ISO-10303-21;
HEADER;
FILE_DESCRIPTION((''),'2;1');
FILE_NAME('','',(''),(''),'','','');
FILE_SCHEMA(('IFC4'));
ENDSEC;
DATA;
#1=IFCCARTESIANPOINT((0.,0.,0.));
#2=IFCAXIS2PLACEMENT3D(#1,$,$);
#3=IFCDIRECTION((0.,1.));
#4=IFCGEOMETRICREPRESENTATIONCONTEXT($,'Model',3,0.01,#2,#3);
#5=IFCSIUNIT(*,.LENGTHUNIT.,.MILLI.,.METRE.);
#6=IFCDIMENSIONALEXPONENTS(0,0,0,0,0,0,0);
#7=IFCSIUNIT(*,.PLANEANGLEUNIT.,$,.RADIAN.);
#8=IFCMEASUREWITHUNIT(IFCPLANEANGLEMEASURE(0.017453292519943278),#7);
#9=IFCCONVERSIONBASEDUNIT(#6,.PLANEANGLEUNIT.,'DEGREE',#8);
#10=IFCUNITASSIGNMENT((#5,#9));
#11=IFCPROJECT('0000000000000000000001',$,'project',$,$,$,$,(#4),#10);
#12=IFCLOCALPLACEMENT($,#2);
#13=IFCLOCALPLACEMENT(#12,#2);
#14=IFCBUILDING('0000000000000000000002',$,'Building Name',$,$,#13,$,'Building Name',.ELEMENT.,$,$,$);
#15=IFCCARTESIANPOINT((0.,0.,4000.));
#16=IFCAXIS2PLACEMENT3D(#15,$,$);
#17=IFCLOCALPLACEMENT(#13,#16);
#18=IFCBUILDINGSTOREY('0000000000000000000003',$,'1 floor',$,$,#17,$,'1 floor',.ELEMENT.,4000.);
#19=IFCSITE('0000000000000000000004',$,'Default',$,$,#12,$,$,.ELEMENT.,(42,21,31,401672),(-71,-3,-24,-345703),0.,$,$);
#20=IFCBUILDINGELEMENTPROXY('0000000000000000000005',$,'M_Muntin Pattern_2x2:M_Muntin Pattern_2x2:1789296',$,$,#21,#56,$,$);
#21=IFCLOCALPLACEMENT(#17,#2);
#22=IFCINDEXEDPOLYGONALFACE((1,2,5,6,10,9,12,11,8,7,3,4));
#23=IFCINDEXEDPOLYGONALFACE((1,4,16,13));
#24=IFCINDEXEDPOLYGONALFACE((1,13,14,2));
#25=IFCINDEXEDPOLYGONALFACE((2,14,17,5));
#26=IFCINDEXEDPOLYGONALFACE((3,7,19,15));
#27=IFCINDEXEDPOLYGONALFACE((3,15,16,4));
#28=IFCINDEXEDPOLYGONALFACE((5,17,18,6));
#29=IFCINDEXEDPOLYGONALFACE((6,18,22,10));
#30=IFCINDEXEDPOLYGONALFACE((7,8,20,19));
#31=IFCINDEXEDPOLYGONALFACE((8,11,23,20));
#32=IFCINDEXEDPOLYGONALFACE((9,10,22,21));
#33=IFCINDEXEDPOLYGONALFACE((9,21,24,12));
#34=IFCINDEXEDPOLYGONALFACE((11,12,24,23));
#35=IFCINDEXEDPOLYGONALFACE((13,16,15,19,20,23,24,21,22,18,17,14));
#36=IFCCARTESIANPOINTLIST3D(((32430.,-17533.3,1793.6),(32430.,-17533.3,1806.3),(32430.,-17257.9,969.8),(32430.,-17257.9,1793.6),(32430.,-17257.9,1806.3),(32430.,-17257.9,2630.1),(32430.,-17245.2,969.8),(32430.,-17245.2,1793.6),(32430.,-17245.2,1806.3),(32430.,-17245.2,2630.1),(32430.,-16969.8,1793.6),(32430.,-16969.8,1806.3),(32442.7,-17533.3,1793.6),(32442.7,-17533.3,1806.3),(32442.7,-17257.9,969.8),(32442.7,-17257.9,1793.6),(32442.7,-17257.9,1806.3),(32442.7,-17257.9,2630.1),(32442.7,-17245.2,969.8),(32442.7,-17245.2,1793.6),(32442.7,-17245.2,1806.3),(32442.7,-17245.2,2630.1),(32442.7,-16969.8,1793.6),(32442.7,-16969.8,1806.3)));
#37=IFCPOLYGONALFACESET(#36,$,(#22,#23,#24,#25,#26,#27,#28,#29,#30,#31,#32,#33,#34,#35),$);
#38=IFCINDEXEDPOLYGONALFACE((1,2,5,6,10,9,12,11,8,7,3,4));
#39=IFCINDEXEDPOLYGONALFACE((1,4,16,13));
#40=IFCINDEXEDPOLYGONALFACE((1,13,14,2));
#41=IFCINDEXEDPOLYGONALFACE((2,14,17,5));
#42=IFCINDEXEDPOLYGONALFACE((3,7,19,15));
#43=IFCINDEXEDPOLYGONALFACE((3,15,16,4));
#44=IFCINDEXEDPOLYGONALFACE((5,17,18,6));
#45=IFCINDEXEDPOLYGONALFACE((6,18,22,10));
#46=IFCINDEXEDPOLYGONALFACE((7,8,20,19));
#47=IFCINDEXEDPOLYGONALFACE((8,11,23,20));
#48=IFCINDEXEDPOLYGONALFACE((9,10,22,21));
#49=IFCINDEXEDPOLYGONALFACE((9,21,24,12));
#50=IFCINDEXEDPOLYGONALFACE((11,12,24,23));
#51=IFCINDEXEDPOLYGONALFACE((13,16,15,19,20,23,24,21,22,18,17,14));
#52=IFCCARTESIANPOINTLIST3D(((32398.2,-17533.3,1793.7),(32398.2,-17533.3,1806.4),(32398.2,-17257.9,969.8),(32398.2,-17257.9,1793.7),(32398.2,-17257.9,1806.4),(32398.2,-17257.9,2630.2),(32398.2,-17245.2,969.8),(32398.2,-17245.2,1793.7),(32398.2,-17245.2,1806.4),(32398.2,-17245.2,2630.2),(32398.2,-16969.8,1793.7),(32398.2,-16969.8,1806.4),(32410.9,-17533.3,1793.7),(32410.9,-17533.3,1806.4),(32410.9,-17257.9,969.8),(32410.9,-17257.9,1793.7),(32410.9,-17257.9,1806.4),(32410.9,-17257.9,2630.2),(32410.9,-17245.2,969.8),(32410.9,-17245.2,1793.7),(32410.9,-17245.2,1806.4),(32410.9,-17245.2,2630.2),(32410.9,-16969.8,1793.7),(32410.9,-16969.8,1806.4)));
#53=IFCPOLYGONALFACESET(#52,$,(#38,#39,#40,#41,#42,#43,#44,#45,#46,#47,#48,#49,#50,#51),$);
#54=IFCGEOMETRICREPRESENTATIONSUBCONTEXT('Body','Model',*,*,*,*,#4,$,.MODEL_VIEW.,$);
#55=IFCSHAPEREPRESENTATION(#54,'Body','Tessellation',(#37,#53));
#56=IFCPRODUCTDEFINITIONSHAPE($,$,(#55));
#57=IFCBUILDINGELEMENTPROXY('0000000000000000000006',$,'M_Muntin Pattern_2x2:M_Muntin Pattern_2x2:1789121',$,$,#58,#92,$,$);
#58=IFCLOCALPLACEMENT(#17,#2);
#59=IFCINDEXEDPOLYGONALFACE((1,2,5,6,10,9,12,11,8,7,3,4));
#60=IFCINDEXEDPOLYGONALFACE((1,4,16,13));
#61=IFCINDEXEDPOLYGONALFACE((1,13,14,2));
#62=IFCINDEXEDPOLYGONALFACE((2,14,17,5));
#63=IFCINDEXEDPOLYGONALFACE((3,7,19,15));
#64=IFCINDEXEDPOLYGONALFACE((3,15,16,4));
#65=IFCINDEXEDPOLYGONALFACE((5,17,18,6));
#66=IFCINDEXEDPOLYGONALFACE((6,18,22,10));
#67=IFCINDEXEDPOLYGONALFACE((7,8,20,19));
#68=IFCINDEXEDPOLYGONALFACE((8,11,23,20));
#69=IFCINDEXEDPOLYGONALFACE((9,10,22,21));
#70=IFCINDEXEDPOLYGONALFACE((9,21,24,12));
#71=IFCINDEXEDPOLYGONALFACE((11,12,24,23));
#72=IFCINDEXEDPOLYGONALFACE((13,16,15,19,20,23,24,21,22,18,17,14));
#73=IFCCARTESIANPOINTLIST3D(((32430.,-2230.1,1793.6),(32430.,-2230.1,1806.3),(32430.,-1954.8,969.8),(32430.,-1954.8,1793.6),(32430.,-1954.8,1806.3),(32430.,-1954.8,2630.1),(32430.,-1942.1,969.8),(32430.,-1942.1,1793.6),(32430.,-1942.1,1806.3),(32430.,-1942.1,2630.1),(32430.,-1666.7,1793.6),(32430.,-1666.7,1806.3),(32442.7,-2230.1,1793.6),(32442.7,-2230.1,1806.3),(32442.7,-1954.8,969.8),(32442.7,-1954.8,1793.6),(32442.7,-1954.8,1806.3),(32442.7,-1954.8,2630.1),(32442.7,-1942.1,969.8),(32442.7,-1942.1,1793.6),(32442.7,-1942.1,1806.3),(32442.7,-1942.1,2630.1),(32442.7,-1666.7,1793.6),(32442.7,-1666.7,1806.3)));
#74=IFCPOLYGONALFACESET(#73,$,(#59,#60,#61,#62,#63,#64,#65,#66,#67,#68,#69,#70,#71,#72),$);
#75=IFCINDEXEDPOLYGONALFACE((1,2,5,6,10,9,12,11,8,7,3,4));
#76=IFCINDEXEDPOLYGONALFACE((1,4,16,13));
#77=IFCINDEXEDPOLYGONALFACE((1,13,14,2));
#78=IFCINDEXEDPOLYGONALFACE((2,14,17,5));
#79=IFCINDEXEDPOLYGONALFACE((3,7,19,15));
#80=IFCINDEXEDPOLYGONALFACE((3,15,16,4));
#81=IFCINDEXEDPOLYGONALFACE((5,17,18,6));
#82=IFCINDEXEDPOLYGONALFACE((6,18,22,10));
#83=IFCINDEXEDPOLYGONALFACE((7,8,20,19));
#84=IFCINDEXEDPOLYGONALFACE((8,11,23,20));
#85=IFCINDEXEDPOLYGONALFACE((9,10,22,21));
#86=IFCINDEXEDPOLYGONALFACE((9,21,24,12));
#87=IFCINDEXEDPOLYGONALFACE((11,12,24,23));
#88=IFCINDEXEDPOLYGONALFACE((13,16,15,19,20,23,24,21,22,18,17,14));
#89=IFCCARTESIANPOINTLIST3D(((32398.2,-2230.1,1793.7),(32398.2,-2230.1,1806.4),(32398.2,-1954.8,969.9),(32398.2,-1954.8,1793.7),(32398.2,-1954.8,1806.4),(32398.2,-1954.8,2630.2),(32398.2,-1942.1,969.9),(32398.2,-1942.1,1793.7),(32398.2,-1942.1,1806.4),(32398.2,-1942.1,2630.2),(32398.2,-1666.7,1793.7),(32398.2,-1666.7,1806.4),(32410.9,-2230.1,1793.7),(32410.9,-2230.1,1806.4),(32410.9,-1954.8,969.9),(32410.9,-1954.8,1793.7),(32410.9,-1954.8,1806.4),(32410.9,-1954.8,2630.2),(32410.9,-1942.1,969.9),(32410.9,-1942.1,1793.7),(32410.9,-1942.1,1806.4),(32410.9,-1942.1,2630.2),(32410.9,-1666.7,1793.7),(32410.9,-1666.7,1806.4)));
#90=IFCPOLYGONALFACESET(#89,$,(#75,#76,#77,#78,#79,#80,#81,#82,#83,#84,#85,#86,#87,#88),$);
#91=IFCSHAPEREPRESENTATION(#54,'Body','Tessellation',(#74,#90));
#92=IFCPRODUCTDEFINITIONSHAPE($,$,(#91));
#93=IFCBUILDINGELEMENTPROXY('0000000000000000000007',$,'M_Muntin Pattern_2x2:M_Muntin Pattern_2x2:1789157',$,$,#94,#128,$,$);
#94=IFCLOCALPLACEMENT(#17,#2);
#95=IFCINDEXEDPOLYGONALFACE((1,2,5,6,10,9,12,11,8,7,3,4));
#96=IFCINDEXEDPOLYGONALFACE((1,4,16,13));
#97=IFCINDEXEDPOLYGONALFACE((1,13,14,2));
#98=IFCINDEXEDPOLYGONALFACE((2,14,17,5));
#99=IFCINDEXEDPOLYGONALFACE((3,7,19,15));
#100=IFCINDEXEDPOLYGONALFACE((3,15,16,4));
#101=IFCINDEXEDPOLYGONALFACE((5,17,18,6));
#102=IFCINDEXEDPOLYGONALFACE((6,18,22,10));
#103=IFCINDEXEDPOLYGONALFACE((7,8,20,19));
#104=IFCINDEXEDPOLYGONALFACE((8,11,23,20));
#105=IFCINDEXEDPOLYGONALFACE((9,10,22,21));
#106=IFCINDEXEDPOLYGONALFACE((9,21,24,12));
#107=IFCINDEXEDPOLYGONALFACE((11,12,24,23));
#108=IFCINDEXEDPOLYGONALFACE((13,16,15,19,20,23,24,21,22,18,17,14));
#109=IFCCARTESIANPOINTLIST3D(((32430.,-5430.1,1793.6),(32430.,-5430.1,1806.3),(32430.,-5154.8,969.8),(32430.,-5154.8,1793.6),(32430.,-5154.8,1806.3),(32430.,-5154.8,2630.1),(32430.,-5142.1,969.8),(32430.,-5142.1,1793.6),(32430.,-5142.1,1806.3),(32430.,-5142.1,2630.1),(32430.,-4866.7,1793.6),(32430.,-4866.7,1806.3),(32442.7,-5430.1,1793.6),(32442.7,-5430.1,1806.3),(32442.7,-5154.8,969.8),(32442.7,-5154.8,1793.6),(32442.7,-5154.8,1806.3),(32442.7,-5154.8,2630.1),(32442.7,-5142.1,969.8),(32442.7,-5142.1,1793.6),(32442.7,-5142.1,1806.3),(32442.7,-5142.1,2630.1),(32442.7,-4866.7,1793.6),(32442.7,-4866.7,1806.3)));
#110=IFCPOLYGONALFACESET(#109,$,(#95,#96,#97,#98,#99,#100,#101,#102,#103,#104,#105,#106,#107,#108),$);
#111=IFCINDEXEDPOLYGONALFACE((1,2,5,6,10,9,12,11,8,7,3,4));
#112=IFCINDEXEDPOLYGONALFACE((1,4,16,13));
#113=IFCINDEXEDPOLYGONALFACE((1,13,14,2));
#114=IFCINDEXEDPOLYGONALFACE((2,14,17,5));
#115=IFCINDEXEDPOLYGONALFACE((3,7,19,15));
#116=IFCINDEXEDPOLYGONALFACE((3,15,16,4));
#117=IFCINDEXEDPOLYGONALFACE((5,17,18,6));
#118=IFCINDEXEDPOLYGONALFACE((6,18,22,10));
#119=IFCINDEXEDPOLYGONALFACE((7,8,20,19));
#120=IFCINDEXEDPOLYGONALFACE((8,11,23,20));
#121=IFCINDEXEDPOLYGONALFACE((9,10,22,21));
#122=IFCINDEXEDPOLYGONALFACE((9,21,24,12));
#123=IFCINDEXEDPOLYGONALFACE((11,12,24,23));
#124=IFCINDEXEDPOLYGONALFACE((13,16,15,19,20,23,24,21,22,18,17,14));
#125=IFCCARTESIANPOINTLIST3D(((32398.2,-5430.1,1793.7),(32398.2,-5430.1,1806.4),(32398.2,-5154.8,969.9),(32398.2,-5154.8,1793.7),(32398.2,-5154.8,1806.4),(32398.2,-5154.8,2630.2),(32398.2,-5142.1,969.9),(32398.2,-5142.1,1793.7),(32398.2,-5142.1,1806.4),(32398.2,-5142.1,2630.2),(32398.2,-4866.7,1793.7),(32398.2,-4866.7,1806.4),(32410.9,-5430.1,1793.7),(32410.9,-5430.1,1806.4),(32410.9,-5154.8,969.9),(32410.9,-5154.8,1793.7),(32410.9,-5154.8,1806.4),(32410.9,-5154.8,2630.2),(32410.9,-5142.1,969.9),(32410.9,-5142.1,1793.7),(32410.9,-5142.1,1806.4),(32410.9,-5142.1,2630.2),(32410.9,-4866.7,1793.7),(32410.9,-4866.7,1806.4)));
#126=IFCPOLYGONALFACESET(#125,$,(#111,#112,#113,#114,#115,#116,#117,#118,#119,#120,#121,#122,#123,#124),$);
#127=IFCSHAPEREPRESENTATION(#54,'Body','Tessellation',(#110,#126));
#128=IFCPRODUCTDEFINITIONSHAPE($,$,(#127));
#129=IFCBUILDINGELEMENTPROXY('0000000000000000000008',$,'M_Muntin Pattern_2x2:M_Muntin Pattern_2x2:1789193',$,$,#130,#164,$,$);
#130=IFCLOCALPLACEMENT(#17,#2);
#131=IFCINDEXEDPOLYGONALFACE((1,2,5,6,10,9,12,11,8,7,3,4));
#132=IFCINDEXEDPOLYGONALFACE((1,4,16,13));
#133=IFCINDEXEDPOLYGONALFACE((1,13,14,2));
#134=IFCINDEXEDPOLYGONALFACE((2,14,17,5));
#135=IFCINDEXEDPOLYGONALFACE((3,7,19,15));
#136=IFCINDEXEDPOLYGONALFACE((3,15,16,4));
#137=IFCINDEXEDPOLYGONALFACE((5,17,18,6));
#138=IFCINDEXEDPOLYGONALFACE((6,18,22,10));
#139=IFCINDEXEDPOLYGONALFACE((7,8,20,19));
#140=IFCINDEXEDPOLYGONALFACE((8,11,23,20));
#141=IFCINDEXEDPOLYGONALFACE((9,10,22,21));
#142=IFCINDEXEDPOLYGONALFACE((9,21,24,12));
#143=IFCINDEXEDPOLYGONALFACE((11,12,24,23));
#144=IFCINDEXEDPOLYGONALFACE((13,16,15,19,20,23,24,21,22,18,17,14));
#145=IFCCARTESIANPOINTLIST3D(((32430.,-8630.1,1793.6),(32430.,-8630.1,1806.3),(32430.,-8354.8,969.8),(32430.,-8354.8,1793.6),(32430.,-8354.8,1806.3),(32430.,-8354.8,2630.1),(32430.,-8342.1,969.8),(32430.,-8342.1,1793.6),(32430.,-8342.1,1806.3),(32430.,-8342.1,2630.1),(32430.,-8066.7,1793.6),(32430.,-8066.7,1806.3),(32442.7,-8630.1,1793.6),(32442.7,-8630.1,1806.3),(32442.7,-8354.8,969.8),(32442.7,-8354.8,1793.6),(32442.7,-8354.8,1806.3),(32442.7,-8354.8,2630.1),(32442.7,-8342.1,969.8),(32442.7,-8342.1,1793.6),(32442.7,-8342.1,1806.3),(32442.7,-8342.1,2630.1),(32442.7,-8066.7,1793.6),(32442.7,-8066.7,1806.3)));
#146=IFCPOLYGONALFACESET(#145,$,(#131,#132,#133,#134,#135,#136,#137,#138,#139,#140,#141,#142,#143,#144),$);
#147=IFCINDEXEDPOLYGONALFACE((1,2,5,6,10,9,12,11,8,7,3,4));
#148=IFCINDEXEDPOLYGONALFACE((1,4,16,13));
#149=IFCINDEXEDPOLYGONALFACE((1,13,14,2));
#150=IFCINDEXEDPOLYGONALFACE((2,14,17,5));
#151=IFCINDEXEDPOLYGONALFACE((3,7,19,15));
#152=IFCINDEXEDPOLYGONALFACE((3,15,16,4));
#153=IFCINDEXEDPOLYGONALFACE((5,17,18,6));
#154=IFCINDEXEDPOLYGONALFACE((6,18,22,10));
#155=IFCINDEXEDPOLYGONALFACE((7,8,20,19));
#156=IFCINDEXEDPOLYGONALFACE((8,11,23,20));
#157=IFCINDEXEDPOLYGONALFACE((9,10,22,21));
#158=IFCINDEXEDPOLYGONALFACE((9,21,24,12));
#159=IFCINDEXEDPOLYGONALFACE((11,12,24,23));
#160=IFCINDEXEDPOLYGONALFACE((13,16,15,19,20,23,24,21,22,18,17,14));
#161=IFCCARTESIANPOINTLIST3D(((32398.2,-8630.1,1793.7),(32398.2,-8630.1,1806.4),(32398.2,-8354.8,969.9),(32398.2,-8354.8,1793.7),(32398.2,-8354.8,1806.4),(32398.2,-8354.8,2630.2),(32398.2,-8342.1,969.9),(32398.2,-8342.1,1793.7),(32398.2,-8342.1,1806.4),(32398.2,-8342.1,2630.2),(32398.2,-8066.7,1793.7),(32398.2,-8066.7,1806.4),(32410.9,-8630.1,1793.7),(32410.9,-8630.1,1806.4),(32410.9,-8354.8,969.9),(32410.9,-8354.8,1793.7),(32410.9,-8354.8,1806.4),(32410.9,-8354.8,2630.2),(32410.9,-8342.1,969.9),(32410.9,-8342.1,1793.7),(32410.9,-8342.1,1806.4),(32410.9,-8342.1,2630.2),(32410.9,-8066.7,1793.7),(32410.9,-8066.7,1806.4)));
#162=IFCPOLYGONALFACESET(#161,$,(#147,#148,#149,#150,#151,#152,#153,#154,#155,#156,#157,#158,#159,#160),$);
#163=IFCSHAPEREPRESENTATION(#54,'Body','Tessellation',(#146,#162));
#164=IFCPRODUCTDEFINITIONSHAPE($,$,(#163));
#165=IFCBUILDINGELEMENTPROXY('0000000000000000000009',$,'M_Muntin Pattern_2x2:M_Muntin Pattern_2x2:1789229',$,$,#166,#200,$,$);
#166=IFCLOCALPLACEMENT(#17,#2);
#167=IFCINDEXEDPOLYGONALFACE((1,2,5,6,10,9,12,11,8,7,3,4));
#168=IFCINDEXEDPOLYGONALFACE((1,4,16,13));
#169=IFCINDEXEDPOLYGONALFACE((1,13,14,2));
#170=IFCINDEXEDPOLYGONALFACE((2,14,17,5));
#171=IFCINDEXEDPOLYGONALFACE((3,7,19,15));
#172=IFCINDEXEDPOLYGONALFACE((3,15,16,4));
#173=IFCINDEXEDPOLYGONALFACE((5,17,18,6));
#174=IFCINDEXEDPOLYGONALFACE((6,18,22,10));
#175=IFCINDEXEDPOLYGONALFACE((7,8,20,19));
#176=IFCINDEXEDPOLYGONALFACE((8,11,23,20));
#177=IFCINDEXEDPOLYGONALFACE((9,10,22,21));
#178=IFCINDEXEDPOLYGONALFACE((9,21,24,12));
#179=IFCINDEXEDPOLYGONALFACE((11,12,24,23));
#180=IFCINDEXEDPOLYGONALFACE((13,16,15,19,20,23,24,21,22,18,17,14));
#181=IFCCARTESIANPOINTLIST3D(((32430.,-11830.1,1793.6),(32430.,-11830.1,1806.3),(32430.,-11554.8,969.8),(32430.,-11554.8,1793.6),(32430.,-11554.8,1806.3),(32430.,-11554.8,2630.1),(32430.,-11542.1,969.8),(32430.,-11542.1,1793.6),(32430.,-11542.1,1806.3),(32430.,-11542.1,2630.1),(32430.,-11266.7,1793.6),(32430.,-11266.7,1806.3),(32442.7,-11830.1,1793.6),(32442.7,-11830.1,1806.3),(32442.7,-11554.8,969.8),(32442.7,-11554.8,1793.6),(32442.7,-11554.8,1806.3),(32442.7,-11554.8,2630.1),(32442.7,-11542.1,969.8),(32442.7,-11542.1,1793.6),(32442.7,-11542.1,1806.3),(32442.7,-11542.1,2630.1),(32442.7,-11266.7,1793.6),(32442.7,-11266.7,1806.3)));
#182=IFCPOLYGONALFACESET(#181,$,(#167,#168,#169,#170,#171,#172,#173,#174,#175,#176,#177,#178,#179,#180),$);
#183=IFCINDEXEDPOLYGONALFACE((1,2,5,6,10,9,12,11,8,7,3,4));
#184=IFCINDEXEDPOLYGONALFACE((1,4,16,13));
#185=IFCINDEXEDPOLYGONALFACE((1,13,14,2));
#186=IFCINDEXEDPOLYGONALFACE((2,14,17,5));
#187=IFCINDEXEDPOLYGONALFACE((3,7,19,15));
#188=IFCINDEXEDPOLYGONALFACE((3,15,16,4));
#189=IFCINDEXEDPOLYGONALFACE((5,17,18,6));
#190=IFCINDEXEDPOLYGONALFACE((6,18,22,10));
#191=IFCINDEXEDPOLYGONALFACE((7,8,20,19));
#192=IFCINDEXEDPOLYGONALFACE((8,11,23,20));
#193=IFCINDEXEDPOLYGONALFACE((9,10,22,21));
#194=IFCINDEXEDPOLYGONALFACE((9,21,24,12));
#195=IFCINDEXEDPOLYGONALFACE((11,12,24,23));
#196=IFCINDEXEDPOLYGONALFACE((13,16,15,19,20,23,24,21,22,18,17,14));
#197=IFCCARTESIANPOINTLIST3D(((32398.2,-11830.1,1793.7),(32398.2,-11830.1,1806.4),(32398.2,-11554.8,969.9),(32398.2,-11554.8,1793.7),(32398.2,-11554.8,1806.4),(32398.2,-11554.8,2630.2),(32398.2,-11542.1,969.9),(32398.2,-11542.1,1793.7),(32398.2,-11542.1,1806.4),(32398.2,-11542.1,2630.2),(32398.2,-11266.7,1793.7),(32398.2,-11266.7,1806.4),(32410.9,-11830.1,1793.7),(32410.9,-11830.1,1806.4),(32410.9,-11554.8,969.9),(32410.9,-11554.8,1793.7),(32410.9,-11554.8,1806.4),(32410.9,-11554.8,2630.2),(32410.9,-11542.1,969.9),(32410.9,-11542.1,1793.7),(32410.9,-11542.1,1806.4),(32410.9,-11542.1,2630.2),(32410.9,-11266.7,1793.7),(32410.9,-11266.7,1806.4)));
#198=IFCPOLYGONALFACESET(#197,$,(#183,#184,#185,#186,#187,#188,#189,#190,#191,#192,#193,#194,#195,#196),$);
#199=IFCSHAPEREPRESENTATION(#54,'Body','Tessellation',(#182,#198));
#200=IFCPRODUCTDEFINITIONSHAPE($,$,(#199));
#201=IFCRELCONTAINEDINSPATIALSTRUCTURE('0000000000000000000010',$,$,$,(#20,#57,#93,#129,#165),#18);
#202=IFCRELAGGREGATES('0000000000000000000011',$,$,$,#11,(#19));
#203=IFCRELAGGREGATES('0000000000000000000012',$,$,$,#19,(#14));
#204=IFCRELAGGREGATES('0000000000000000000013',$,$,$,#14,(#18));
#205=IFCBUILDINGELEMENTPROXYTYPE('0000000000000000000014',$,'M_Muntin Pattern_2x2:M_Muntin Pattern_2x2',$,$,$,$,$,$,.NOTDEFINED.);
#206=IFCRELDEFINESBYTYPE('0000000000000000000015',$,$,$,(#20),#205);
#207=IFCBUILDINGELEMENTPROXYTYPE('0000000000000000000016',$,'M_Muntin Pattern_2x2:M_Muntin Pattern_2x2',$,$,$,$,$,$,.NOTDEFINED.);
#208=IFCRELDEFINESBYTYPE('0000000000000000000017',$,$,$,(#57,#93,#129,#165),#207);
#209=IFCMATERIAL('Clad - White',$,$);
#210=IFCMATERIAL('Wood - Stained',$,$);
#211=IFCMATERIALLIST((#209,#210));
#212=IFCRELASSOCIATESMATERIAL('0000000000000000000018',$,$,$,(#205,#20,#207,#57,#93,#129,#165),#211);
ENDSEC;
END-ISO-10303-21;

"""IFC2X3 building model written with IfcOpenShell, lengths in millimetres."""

from ifc_helpers import new_model, entity, si_unit, converted_unit, direction, frame, origin, place, context, subcontext, project, spatial, polyline, outline, extrude, source, transform, mapped, material, material_list, type_object, type_shapes, element, save


model = new_model("IFC2X3")

# Units and contexts
model_context = context("Model", 3, precision=0.01, world=origin(), true_north=direction((0.0, 1.0)))
body_context = subcontext(model_context, "Body", "Model", "MODEL_VIEW")
ifc_project = project(units=[si_unit("LENGTHUNIT", "METRE", prefix="MILLI"), converted_unit("PLANEANGLEUNIT", "DEGREE", entity("IfcPlaneAngleMeasure", 0.017453292519943278), si_unit("PLANEANGLEUNIT", "RADIAN"), dimensions=[0, 0, 0, 0, 0, 0, 0])], contexts=[model_context])

# Site, building, storey
site_placement = place(None, origin())
site = spatial("IfcSite", under=ifc_project, at=site_placement, Name="Default", CompositionType="ELEMENT", RefLatitude=(42, 21, 31, 401672), RefLongitude=(-71, -3, -24, -345703), RefElevation=0.0)
building_placement = place(site_placement, origin())
building = spatial("IfcBuilding", under=site, at=building_placement, Name="Building Name", LongName="Building Name", CompositionType="ELEMENT")
storey_placement = place(building_placement, frame((0.0, 0.0, 4000.0)))
storey = spatial("IfcBuildingStorey", under=building, at=storey_placement, Name="1 floor", LongName="1 floor", CompositionType="ELEMENT", Elevation=4000.0)

# Building element proxies
ifc_material_1 = material(Name="Clad - White")
ifc_material_2 = material(Name="Wood - Stained")
ifc_material_list = material_list([ifc_material_1, ifc_material_2])
building_element_proxy_type_1 = type_object("IfcBuildingElementProxyType", Name="M_Muntin Pattern_2x2:M_Muntin Pattern_2x2", PredefinedType="NOTDEFINED", material=ifc_material_list)
shared_shape_1 = source(origin(), body_context, "Body", "SweptSolid", [
    extrude(outline(polyline([(6.4, -6.4), (830.1, -6.4), (830.1, 6.3), (6.4, 6.3), (6.4, 281.7), (-6.3, 281.7), (-6.3, 6.3), (-830.2, 6.3), (-830.2, -6.4), (-6.3, -6.4), (-6.3, -281.7), (6.4, -281.7), (6.4, -6.4)])), frame((0.0, 9.5, 830.1), z_axis=(0.0, 1.0, 0.0), x_axis=(0.0, 0.0, 1.0)), (0.0, 0.0, 1.0), 12.7),
    extrude(outline(polyline([(6.4, -6.4), (830.2, -6.4), (830.2, 6.3), (6.4, 6.3), (6.4, 281.7), (-6.3, 281.7), (-6.3, 6.3), (-830.2, 6.3), (-830.2, -6.4), (-6.3, -6.4), (-6.3, -281.7), (6.4, -281.7), (6.4, -6.4)])), frame((0.0, -22.2, 830.2), z_axis=(0.0, 1.0, 0.0), x_axis=(0.0, 0.0, 1.0)), (0.0, 0.0, 1.0), 12.7),
])
type_shapes(building_element_proxy_type_1, [shared_shape_1])
for number, where, z_axis, x_axis, name in (
    (1, (32420.5, -17251.6, 969.8), (0.0, 0.0, 1.0), (0.0, -1.0, 0.0), "M_Muntin Pattern_2x2:M_Muntin Pattern_2x2:1789296"),
):
    element("IfcBuildingElementProxy", number, at=place(storey_placement, frame(where, z_axis=z_axis, x_axis=x_axis)), inside=storey, type_object=building_element_proxy_type_1, material=ifc_material_list, Name=name, context=body_context, shape_type="MappedRepresentation", body=[
        mapped(shared_shape_1, transform((0.0, 0.0, 0.0), scale=1.0)),
    ])
building_element_proxy_type_2 = type_object("IfcBuildingElementProxyType", Name="M_Muntin Pattern_2x2:M_Muntin Pattern_2x2", PredefinedType="NOTDEFINED", material=ifc_material_list)
shared_shape_2 = source(origin(), body_context, "Body", "SweptSolid", [
    extrude(outline(polyline([(6.4, -6.4), (830.1, -6.4), (830.1, 6.3), (6.4, 6.3), (6.4, 281.7), (-6.3, 281.7), (-6.3, 6.3), (-830.2, 6.3), (-830.2, -6.4), (-6.3, -6.4), (-6.3, -281.7), (6.4, -281.7), (6.4, -6.4)])), frame((0.0, -22.2, 830.1), z_axis=(0.0, 1.0, 0.0), x_axis=(0.0, 0.0, 1.0)), (0.0, 0.0, 1.0), 12.7),
    extrude(outline(polyline([(6.4, -6.4), (830.2, -6.4), (830.2, 6.3), (6.4, 6.3), (6.4, 281.7), (-6.3, 281.7), (-6.3, 6.3), (-830.2, 6.3), (-830.2, -6.4), (-6.3, -6.4), (-6.3, -281.7), (6.4, -281.7), (6.4, -6.4)])), frame((0.0, 9.5, 830.2), z_axis=(0.0, 1.0, 0.0), x_axis=(0.0, 0.0, 1.0)), (0.0, 0.0, 1.0), 12.7),
])
type_shapes(building_element_proxy_type_2, [shared_shape_2])
for number, where, z_axis, x_axis, name in (
    (2, (32420.5, -1948.4, 969.9), (0.0, 0.0, 1.0), (0.0, 1.0, 0.0), "M_Muntin Pattern_2x2:M_Muntin Pattern_2x2:1789121"),
    (3, (32420.5, -5148.4, 969.9), (0.0, 0.0, 1.0), (0.0, 1.0, 0.0), "M_Muntin Pattern_2x2:M_Muntin Pattern_2x2:1789157"),
    (4, (32420.5, -8348.4, 969.9), (0.0, 0.0, 1.0), (0.0, 1.0, 0.0), "M_Muntin Pattern_2x2:M_Muntin Pattern_2x2:1789193"),
    (5, (32420.5, -11548.4, 969.9), (0.0, 0.0, 1.0), (0.0, 1.0, 0.0), "M_Muntin Pattern_2x2:M_Muntin Pattern_2x2:1789229"),
):
    element("IfcBuildingElementProxy", number, at=place(storey_placement, frame(where, z_axis=z_axis, x_axis=x_axis)), inside=storey, type_object=building_element_proxy_type_2, material=ifc_material_list, Name=name, context=body_context, shape_type="MappedRepresentation", body=[
        mapped(shared_shape_2, transform((0.0, 0.0, 0.0), scale=1.0)),
    ])

save(model, "model.ifc")
